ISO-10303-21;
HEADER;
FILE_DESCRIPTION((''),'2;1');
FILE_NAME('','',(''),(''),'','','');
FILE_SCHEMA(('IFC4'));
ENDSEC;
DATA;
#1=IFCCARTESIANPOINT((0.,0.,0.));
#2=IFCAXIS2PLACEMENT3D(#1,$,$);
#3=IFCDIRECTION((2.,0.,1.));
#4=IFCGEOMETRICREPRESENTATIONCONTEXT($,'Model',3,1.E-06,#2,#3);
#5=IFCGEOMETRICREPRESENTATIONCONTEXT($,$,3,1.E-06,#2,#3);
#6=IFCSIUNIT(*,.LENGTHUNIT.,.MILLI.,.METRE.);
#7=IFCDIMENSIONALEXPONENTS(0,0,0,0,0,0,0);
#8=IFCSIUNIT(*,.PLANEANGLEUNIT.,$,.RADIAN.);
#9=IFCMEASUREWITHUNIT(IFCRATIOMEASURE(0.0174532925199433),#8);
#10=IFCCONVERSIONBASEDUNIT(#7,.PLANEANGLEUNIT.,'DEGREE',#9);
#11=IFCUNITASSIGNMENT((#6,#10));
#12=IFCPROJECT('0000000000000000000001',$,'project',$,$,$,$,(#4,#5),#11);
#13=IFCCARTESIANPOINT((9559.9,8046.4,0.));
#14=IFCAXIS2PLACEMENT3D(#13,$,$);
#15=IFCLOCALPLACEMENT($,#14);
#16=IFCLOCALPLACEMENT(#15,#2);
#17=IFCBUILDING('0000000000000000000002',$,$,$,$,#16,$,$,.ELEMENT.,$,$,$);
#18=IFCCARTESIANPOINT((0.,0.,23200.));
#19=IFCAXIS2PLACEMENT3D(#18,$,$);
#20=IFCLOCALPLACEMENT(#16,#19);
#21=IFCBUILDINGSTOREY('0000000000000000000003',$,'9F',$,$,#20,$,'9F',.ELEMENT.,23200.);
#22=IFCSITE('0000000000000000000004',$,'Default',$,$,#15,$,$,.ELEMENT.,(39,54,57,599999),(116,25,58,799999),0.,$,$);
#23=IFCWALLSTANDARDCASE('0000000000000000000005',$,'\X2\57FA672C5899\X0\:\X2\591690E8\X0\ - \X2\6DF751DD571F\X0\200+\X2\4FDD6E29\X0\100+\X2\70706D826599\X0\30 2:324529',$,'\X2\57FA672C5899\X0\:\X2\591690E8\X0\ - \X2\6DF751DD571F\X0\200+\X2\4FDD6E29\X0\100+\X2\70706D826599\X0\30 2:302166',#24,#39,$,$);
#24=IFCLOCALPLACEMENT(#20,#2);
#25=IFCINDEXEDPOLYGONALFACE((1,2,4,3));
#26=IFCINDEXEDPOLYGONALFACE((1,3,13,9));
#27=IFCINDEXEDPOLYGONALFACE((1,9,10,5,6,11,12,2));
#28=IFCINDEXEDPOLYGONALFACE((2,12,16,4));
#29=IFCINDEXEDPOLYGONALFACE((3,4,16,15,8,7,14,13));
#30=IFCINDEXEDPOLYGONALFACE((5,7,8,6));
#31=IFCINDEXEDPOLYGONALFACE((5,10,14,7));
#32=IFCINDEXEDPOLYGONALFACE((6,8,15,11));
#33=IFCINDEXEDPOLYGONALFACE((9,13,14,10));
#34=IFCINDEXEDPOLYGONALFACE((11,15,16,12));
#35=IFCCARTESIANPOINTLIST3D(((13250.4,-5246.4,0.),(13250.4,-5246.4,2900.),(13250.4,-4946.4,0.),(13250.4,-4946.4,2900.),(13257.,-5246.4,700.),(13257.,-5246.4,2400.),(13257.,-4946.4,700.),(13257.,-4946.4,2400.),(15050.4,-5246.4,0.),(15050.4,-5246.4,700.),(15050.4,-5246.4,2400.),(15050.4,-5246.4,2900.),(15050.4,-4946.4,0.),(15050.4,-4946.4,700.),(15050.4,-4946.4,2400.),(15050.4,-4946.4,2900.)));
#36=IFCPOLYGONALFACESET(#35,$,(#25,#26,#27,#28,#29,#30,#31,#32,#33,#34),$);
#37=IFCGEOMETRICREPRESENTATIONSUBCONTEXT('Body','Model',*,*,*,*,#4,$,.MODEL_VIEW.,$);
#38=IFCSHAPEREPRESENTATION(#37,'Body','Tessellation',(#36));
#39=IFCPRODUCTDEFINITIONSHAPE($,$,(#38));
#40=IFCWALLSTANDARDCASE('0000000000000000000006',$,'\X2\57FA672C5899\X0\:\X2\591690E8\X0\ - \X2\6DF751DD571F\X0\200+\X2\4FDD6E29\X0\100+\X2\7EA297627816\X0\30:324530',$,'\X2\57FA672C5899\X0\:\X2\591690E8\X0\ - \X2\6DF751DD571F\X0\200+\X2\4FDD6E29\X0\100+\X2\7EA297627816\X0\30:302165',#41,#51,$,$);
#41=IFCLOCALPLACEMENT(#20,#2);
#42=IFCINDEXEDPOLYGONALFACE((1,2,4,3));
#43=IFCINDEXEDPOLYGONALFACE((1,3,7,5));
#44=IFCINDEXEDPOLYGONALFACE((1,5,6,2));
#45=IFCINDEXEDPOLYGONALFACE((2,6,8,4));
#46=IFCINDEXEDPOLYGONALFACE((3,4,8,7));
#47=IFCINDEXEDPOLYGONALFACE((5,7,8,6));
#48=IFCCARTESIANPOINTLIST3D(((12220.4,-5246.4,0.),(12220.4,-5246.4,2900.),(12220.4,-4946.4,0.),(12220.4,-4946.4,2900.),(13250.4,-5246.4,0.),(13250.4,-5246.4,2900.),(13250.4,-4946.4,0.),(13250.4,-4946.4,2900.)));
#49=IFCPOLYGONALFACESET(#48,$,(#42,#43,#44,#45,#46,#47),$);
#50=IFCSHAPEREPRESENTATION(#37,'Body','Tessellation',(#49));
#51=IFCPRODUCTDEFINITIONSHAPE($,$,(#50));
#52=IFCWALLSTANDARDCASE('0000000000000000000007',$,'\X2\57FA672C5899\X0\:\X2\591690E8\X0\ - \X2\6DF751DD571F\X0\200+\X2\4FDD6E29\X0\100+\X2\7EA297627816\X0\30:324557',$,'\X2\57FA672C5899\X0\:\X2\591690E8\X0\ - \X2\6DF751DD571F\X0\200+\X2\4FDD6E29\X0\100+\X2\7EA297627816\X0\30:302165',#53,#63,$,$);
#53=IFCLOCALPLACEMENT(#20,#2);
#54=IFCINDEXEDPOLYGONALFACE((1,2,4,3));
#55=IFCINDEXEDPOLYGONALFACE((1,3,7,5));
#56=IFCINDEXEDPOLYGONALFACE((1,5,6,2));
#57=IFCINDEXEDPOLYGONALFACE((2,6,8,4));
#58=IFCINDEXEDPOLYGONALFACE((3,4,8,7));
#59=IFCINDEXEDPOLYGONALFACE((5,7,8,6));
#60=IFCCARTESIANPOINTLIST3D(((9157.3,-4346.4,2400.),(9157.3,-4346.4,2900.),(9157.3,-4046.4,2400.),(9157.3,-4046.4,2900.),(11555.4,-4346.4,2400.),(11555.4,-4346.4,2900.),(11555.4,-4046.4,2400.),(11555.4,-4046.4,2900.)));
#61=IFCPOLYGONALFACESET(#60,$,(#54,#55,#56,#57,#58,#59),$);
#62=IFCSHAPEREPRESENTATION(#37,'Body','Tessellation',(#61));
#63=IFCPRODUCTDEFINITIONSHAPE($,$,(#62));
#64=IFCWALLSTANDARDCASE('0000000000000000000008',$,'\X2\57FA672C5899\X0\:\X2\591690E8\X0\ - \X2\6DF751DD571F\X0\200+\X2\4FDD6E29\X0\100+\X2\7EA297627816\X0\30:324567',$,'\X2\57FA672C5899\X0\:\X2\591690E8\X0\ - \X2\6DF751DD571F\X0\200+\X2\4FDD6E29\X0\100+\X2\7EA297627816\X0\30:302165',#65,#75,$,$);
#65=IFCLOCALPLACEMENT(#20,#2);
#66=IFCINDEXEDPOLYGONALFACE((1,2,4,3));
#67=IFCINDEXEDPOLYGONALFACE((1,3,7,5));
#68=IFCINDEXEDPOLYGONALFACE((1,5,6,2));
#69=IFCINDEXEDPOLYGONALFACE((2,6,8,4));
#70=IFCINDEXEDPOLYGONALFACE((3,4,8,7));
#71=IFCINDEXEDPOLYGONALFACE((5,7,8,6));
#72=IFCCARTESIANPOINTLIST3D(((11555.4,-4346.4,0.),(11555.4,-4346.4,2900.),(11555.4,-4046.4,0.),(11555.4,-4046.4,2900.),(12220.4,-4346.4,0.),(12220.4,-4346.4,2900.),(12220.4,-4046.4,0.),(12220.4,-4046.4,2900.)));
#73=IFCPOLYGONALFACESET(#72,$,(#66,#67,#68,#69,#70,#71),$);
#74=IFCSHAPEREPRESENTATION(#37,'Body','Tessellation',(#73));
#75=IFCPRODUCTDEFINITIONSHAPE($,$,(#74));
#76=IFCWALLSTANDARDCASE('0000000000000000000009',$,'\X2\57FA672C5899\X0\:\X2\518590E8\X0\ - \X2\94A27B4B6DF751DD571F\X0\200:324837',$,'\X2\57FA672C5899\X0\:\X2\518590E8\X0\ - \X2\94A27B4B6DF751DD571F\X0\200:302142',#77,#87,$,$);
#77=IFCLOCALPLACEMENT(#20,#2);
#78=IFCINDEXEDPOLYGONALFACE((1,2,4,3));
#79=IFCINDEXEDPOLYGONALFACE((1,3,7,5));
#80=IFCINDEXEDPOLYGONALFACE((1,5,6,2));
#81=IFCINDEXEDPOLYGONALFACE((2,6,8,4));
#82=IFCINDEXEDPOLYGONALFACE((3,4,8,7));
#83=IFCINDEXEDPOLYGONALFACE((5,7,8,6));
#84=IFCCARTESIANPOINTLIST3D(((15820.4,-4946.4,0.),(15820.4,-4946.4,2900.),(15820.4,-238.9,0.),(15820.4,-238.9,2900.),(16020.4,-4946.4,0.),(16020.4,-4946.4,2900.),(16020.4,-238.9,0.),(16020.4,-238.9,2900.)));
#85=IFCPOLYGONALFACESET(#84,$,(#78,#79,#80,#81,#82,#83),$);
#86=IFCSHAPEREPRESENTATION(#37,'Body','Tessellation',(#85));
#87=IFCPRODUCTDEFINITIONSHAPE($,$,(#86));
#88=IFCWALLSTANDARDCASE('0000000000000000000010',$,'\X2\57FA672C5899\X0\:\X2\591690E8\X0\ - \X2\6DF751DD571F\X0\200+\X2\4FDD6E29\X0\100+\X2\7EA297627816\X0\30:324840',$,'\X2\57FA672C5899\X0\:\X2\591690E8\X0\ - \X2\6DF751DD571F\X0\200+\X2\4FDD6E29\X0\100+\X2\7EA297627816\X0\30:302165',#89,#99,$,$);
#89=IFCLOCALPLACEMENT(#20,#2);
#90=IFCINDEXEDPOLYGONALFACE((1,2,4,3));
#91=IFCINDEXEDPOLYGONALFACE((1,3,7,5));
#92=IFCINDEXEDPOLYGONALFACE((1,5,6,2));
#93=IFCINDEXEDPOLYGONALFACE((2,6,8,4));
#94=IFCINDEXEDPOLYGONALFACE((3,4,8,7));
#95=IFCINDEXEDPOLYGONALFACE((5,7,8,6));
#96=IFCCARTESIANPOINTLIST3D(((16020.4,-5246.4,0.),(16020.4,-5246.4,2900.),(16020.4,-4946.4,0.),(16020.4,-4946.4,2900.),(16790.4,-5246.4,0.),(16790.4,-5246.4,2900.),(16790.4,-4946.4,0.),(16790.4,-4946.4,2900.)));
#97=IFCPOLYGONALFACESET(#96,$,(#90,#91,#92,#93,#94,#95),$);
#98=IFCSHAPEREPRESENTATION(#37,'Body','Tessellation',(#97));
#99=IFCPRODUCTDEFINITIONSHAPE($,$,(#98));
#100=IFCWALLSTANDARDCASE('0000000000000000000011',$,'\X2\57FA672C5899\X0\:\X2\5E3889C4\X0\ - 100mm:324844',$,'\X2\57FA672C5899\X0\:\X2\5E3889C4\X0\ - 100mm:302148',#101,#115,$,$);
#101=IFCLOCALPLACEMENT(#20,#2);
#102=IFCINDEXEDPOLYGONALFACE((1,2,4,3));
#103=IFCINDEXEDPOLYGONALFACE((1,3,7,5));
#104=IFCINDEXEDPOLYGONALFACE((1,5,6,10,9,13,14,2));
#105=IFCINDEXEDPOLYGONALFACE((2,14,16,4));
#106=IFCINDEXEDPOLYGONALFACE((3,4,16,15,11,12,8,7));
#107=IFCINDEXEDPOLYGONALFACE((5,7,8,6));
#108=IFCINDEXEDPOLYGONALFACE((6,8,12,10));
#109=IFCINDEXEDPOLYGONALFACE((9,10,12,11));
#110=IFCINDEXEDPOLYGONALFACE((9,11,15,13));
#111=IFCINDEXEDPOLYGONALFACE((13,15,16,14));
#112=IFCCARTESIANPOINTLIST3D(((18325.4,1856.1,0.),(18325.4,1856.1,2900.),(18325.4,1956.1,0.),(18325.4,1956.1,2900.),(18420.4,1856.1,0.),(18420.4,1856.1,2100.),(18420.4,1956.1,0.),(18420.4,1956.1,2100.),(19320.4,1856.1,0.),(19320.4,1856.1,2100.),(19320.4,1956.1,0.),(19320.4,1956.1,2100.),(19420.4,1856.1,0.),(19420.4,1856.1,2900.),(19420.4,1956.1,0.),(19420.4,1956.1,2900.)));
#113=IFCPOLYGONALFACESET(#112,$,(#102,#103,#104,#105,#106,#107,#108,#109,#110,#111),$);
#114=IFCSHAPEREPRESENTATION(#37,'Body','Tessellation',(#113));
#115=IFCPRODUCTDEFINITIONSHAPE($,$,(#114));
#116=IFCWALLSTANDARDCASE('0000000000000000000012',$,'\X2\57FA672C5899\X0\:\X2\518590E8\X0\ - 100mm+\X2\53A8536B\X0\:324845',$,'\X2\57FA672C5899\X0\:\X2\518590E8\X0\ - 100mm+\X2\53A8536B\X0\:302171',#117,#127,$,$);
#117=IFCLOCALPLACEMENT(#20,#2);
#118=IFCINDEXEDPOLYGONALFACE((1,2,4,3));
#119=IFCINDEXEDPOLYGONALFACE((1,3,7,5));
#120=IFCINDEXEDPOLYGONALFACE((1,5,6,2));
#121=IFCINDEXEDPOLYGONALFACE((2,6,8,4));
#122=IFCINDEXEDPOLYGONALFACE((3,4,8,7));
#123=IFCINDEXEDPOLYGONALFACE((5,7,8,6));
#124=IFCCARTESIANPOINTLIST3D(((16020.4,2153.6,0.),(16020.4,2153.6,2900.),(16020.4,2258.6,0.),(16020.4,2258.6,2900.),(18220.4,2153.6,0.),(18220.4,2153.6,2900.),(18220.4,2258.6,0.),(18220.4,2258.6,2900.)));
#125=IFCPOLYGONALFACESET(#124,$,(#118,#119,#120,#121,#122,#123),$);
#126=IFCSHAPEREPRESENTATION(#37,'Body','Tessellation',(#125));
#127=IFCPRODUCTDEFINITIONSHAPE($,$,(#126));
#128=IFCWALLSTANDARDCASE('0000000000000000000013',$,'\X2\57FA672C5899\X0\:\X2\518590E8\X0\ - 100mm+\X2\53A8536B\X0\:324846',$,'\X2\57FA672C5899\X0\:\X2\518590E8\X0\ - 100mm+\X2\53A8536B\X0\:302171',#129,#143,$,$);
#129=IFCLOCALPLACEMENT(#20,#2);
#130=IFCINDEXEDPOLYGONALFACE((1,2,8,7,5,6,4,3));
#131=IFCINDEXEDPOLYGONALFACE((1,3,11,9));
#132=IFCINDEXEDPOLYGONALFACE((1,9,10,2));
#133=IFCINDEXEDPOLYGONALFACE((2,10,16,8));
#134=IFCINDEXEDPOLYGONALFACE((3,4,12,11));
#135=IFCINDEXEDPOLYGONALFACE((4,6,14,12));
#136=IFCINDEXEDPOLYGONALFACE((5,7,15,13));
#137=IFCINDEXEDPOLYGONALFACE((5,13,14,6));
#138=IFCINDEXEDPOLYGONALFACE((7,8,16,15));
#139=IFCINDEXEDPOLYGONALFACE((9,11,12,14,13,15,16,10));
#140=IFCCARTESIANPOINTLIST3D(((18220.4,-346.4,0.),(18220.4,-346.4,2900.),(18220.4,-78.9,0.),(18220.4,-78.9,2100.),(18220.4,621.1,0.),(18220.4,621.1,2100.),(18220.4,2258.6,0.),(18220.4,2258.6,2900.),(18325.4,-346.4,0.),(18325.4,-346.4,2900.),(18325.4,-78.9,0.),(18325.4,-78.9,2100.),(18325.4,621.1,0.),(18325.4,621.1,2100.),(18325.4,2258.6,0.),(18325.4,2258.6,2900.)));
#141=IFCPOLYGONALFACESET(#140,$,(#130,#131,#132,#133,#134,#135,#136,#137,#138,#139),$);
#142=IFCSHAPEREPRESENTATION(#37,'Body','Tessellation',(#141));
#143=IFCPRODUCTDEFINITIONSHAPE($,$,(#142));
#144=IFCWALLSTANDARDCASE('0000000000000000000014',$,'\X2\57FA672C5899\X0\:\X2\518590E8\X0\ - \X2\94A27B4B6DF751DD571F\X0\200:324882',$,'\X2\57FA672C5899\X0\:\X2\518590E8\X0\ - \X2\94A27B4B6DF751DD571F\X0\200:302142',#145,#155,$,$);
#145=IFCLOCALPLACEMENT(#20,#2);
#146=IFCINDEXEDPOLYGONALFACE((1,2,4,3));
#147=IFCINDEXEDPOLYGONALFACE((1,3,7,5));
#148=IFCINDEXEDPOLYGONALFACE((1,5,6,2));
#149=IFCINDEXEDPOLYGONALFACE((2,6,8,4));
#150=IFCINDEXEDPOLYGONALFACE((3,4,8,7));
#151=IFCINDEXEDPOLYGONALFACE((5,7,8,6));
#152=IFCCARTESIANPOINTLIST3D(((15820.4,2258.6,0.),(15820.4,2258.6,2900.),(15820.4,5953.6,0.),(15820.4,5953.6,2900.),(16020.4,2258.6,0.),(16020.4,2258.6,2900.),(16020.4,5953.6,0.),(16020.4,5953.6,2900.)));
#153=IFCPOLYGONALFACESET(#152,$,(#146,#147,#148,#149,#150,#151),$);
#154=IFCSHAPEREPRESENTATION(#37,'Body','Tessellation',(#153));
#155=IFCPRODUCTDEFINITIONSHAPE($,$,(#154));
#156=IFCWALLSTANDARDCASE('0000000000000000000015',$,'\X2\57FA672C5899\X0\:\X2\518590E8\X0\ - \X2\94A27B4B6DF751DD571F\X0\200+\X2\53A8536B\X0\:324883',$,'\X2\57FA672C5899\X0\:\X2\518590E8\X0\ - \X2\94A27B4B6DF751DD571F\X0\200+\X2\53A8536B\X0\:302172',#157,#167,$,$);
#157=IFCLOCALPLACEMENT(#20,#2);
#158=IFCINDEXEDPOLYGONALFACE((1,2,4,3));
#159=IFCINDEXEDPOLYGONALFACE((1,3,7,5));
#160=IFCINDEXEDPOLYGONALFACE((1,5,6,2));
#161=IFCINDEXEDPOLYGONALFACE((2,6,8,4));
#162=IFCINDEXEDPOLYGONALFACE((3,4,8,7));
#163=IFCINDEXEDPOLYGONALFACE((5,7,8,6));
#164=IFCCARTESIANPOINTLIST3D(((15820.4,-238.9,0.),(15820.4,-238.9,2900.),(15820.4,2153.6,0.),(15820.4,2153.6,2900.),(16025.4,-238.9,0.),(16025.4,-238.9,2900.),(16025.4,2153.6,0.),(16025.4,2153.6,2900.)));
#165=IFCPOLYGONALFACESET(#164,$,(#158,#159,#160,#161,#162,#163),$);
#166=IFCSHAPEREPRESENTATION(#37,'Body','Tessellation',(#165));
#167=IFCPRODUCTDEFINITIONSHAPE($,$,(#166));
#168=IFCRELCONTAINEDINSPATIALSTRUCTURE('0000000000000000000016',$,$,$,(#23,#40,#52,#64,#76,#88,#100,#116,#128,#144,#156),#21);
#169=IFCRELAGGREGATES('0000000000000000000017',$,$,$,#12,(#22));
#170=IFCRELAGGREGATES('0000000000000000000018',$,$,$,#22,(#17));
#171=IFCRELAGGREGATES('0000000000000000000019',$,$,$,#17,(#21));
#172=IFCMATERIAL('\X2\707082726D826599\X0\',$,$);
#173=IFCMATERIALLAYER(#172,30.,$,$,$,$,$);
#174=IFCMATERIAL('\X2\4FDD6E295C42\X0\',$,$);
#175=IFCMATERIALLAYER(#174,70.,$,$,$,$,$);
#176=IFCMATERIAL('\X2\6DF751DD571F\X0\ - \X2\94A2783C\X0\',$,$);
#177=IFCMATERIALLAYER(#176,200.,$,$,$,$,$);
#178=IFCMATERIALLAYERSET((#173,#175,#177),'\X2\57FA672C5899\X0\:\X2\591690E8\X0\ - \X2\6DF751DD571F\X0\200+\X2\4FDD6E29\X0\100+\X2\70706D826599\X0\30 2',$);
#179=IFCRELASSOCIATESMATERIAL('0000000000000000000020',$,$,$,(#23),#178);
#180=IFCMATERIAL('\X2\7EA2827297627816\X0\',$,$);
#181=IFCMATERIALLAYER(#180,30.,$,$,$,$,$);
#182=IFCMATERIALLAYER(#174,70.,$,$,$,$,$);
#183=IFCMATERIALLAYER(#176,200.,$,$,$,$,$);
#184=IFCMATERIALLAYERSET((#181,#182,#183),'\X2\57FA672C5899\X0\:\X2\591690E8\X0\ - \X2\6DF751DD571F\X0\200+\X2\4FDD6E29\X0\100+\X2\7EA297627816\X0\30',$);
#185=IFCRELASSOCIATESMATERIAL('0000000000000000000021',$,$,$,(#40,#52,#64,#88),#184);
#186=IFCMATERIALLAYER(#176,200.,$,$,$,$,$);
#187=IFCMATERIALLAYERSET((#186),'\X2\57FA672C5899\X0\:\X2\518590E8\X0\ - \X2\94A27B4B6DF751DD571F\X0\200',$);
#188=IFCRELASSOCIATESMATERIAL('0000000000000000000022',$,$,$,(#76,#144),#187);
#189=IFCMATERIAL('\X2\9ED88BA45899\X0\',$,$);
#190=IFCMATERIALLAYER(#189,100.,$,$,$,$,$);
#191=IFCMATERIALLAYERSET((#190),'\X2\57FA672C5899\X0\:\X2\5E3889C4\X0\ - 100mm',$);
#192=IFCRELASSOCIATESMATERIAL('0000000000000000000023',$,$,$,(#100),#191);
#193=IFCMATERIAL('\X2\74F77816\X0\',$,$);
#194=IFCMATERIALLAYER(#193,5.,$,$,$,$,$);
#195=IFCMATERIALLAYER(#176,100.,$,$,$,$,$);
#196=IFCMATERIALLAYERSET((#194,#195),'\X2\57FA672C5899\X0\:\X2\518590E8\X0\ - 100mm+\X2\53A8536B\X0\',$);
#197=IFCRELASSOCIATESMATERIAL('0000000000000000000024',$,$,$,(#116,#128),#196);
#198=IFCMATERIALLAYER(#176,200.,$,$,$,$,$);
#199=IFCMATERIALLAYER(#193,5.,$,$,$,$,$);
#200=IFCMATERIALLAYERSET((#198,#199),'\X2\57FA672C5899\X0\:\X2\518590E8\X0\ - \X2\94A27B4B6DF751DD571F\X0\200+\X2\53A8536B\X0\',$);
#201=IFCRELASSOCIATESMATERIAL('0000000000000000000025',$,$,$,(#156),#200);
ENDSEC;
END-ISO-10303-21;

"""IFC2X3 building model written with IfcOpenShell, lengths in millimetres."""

from ifc_helpers import new_model, entity, si_unit, converted_unit, direction, frame, frame_2d, origin, place, context, subcontext, project, spatial, rectangle, extrude, material, layer, layer_set, layer_usage, element, save


model = new_model("IFC2X3")

# Units and contexts
model_context = context("Model", 3, precision=1e-06, world=origin(), true_north=direction((2.0, 0.0, 1.0)))
context_of_model = context(None, 3, precision=1e-06, world=origin(), true_north=direction((2.0, 0.0, 1.0)))
body_context = subcontext(model_context, "Body", "Model", "MODEL_VIEW")
ifc_project = project(units=[si_unit("LENGTHUNIT", "METRE", prefix="MILLI"), converted_unit("PLANEANGLEUNIT", "DEGREE", entity("IfcRatioMeasure", 0.0174532925199433), si_unit("PLANEANGLEUNIT", "RADIAN"), dimensions=[0, 0, 0, 0, 0, 0, 0])], contexts=[model_context, context_of_model])

# Site, building, storey
site_placement = place(None, frame((9559.9, 8046.4, 0.0)))
site = spatial("IfcSite", under=ifc_project, at=site_placement, Name="Default", CompositionType="ELEMENT", RefLatitude=(39, 54, 57, 599999), RefLongitude=(116, 25, 58, 799999), RefElevation=0.0)
building_placement = place(site_placement, origin())
building = spatial("IfcBuilding", under=site, at=building_placement, CompositionType="ELEMENT")
storey_placement = place(building_placement, frame((0.0, 0.0, 23200.0)))
storey = spatial("IfcBuildingStorey", under=building, at=storey_placement, Name="9F", LongName="9F", CompositionType="ELEMENT", Elevation=23200.0)

# Shared definitions
ifc_material_1 = material(Name="混凝土 - 钢砼")
ifc_layer_1 = layer(ifc_material_1, 200.0)
ifc_layer_set_1 = layer_set([ifc_layer_1], Name="基本墙:内部 - 钢筋混凝土200")
ifc_material_2 = material(Name="红色面砖")
ifc_layer_2 = layer(ifc_material_2, 30.0)
ifc_material_3 = material(Name="保温层")
ifc_layer_3 = layer(ifc_material_3, 70.0)
ifc_layer_4 = layer(ifc_material_1, 200.0)
ifc_layer_set_2 = layer_set([ifc_layer_2, ifc_layer_3, ifc_layer_4], Name="基本墙:外部 - 混凝土200+保温100+红面砖30")

# Shared definitions
ifc_material_4 = material(Name="默认墙")
ifc_layer_5 = layer(ifc_material_4, 100.0)
ifc_layer_set_3 = layer_set([ifc_layer_5], Name="基本墙:常规 - 100mm")

# Shared definitions
ifc_material_5 = material(Name="瓷砖")
ifc_layer_6 = layer(ifc_material_5, 5.0)
ifc_layer_7 = layer(ifc_material_1, 100.0)
ifc_layer_set_4 = layer_set([ifc_layer_6, ifc_layer_7], Name="基本墙:内部 - 100mm+厨卫")

# Shared definitions
ifc_layer_8 = layer(ifc_material_1, 200.0)
ifc_layer_9 = layer(ifc_material_5, 5.0)
ifc_layer_set_5 = layer_set([ifc_layer_8, ifc_layer_9], Name="基本墙:内部 - 钢筋混凝土200+厨卫")

# Wall, opening
ifc_material_6 = material(Name="灰色涂料")
ifc_layer_10 = layer(ifc_material_6, 30.0)
ifc_layer_11 = layer(ifc_material_3, 70.0)
ifc_layer_12 = layer(ifc_material_1, 200.0)
ifc_layer_set_6 = layer_set([ifc_layer_10, ifc_layer_11, ifc_layer_12], Name="基本墙:外部 - 混凝土200+保温100+灰涂料30 2")
ifc_layer_usage_1 = layer_usage(ifc_layer_set_6, "AXIS2", "NEGATIVE", 150.0)
wall_1_placement = place(storey_placement, frame((15050.4, -5096.4, 0.0), z_axis=(0.0, 0.0, 1.0), x_axis=(-1.0, 0.0, 0.0)))
wall_1 = element("IfcWallStandardCase", 1, at=wall_1_placement, inside=storey, material=ifc_layer_usage_1, Name="基本墙:外部 - 混凝土200+保温100+灰涂料30 2:324529", ObjectType="基本墙:外部 - 混凝土200+保温100+灰涂料30 2:302166", context=body_context, shape_type="SweptSolid", body=[
    extrude(rectangle(XDim=1800.0, YDim=300.0, at=frame_2d((900.0, 0.0), x_axis=(-1.0, 0.0))), origin(), (0.0, 0.0, 1.0), 2900.0),
])
opening_1_placement = place(wall_1_placement, frame((-6.6, -150.0, 700.0)))
element("IfcOpeningElement", 2, at=opening_1_placement, cuts=wall_1, ObjectType="Opening", context=body_context, shape_type="SweptSolid", body=[
    extrude(rectangle(XDim=1700.0, YDim=1800.0, at=frame_2d((850.0, 900.0), x_axis=(1.0, 0.0))), frame((0.0, 0.0, 0.0), z_axis=(0.0, 1.0, 0.0), x_axis=(0.0, 0.0, 1.0)), (0.0, 0.0, 1.0), 300.0),
])

# Walls
ifc_layer_usage_2 = layer_usage(ifc_layer_set_2, "AXIS2", "NEGATIVE", 150.0)
wall_2_placement = place(storey_placement, frame((13250.4, -5096.4, 0.0), z_axis=(0.0, 0.0, 1.0), x_axis=(-1.0, 0.0, 0.0)))
element("IfcWallStandardCase", 3, at=wall_2_placement, inside=storey, material=ifc_layer_usage_2, Name="基本墙:外部 - 混凝土200+保温100+红面砖30:324530", ObjectType="基本墙:外部 - 混凝土200+保温100+红面砖30:302165", context=body_context, shape_type="SweptSolid", body=[
    extrude(rectangle(XDim=1030.0, YDim=300.0, at=frame_2d((515.0, 0.0), x_axis=(-1.0, 0.0))), origin(), (0.0, 0.0, 1.0), 2900.0),
])
ifc_layer_usage_3 = layer_usage(ifc_layer_set_2, "AXIS2", "NEGATIVE", 150.0)
wall_3_placement = place(storey_placement, frame((11555.4, -4196.4, 2400.0), z_axis=(0.0, 0.0, 1.0), x_axis=(-1.0, 0.0, 0.0)))
element("IfcWallStandardCase", 4, at=wall_3_placement, inside=storey, material=ifc_layer_usage_3, Name="基本墙:外部 - 混凝土200+保温100+红面砖30:324557", ObjectType="基本墙:外部 - 混凝土200+保温100+红面砖30:302165", context=body_context, shape_type="SweptSolid", body=[
    extrude(rectangle(XDim=2398.1, YDim=300.0, at=frame_2d((1199.0, 0.0), x_axis=(-1.0, 0.0))), origin(), (0.0, 0.0, 1.0), 500.0),
])

# Walls
ifc_layer_usage_4 = layer_usage(ifc_layer_set_2, "AXIS2", "NEGATIVE", 150.0)
wall_4_placement = place(storey_placement, frame((12220.4, -4196.4, 0.0), z_axis=(0.0, 0.0, 1.0), x_axis=(-1.0, 0.0, 0.0)))
element("IfcWallStandardCase", 5, at=wall_4_placement, inside=storey, material=ifc_layer_usage_4, Name="基本墙:外部 - 混凝土200+保温100+红面砖30:324567", ObjectType="基本墙:外部 - 混凝土200+保温100+红面砖30:302165", context=body_context, shape_type="SweptSolid", body=[
    extrude(rectangle(XDim=665.0, YDim=300.0, at=frame_2d((332.5, 0.0), x_axis=(-1.0, 0.0))), origin(), (0.0, 0.0, 1.0), 2900.0),
])
ifc_layer_usage_5 = layer_usage(ifc_layer_set_1, "AXIS2", "NEGATIVE", 100.0)
wall_5_placement = place(storey_placement, frame((15920.4, -4946.4, 0.0), z_axis=(0.0, 0.0, 1.0), x_axis=(0.0, 1.0, 0.0)))
element("IfcWallStandardCase", 6, at=wall_5_placement, inside=storey, material=ifc_layer_usage_5, Name="基本墙:内部 - 钢筋混凝土200:324837", ObjectType="基本墙:内部 - 钢筋混凝土200:302142", context=body_context, shape_type="SweptSolid", body=[
    extrude(rectangle(XDim=4707.5, YDim=200.0, at=frame_2d((2353.8, 0.0), x_axis=(-1.0, 0.0))), origin(), (0.0, 0.0, 1.0), 2900.0),
])
ifc_layer_usage_6 = layer_usage(ifc_layer_set_2, "AXIS2", "POSITIVE", -150.0)
wall_6_placement = place(storey_placement, frame((16020.4, -5096.4, 0.0)))
element("IfcWallStandardCase", 7, at=wall_6_placement, inside=storey, material=ifc_layer_usage_6, Name="基本墙:外部 - 混凝土200+保温100+红面砖30:324840", ObjectType="基本墙:外部 - 混凝土200+保温100+红面砖30:302165", context=body_context, shape_type="SweptSolid", body=[
    extrude(rectangle(XDim=770.0, YDim=300.0, at=frame_2d((385.0, 0.0), x_axis=(-1.0, 0.0))), origin(), (0.0, 0.0, 1.0), 2900.0),
])

# Wall, opening
ifc_layer_usage_7 = layer_usage(ifc_layer_set_3, "AXIS2", "NEGATIVE", 50.0)
wall_7_placement = place(storey_placement, frame((18325.4, 1906.1, 0.0)))
wall_7 = element("IfcWallStandardCase", 8, at=wall_7_placement, inside=storey, material=ifc_layer_usage_7, Name="基本墙:常规 - 100mm:324844", ObjectType="基本墙:常规 - 100mm:302148", context=body_context, shape_type="SweptSolid", body=[
    extrude(rectangle(XDim=1095.0, YDim=100.0, at=frame_2d((547.5, 0.0), x_axis=(-1.0, 0.0))), origin(), (0.0, 0.0, 1.0), 2900.0),
])
opening_2_placement = place(wall_7_placement, frame((95.0, -50.0, 0.0)))
element("IfcOpeningElement", 9, at=opening_2_placement, cuts=wall_7, ObjectType="Opening", context=body_context, shape_type="SweptSolid", body=[
    extrude(rectangle(XDim=2100.0, YDim=900.0, at=frame_2d((1050.0, 450.0), x_axis=(1.0, 0.0))), frame((0.0, 0.0, 0.0), z_axis=(0.0, 1.0, 0.0), x_axis=(0.0, 0.0, 1.0)), (0.0, 0.0, 1.0), 100.0),
])

# Wall
ifc_layer_usage_8 = layer_usage(ifc_layer_set_4, "AXIS2", "POSITIVE", -52.5)
wall_8_placement = place(storey_placement, frame((16020.4, 2206.1, 0.0)))
element("IfcWallStandardCase", 10, at=wall_8_placement, inside=storey, material=ifc_layer_usage_8, Name="基本墙:内部 - 100mm+厨卫:324845", ObjectType="基本墙:内部 - 100mm+厨卫:302171", context=body_context, shape_type="SweptSolid", body=[
    extrude(rectangle(XDim=2200.0, YDim=105.0, at=frame_2d((1100.0, 0.0), x_axis=(-1.0, 0.0))), origin(), (0.0, 0.0, 1.0), 2900.0),
])

# Wall, opening
ifc_layer_usage_9 = layer_usage(ifc_layer_set_4, "AXIS2", "POSITIVE", -52.5)
wall_9_placement = place(storey_placement, frame((18272.9, 2258.6, 0.0), z_axis=(0.0, 0.0, 1.0), x_axis=(0.0, -1.0, 0.0)))
wall_9 = element("IfcWallStandardCase", 11, at=wall_9_placement, inside=storey, material=ifc_layer_usage_9, Name="基本墙:内部 - 100mm+厨卫:324846", ObjectType="基本墙:内部 - 100mm+厨卫:302171", context=body_context, shape_type="SweptSolid", body=[
    extrude(rectangle(XDim=2605.0, YDim=105.0, at=frame_2d((1302.5, 0.0), x_axis=(-1.0, 0.0))), origin(), (0.0, 0.0, 1.0), 2900.0),
])
opening_3_placement = place(wall_9_placement, frame((2337.5, 52.5, 0.0)))
element("IfcOpeningElement", 12, at=opening_3_placement, cuts=wall_9, ObjectType="Opening", context=body_context, shape_type="SweptSolid", body=[
    extrude(rectangle(XDim=2100.0, YDim=700.0, at=frame_2d((1050.0, 350.0), x_axis=(1.0, 0.0))), frame((0.0, 0.0, 0.0), z_axis=(0.0, -1.0, 0.0), x_axis=(0.0, 0.0, 1.0)), (0.0, 0.0, 1.0), 105.0),
])

# Walls
ifc_layer_usage_10 = layer_usage(ifc_layer_set_1, "AXIS2", "NEGATIVE", 100.0)
wall_10_placement = place(storey_placement, frame((15920.4, 2258.6, 0.0), z_axis=(0.0, 0.0, 1.0), x_axis=(0.0, 1.0, 0.0)))
element("IfcWallStandardCase", 13, at=wall_10_placement, inside=storey, material=ifc_layer_usage_10, Name="基本墙:内部 - 钢筋混凝土200:324882", ObjectType="基本墙:内部 - 钢筋混凝土200:302142", context=body_context, shape_type="SweptSolid", body=[
    extrude(rectangle(XDim=3695.0, YDim=200.0, at=frame_2d((1847.5, 0.0), x_axis=(-1.0, 0.0))), origin(), (0.0, 0.0, 1.0), 2900.0),
])
ifc_layer_usage_11 = layer_usage(ifc_layer_set_5, "AXIS2", "NEGATIVE", 102.5)
wall_11_placement = place(storey_placement, frame((15922.9, -238.9, 0.0), z_axis=(0.0, 0.0, 1.0), x_axis=(0.0, 1.0, 0.0)))
element("IfcWallStandardCase", 14, at=wall_11_placement, inside=storey, material=ifc_layer_usage_11, Name="基本墙:内部 - 钢筋混凝土200+厨卫:324883", ObjectType="基本墙:内部 - 钢筋混凝土200+厨卫:302172", context=body_context, shape_type="SweptSolid", body=[
    extrude(rectangle(XDim=2392.5, YDim=205.0, at=frame_2d((1196.2, 0.0), x_axis=(-1.0, 0.0))), origin(), (0.0, 0.0, 1.0), 2900.0),
])

save(model, "model.ifc")
